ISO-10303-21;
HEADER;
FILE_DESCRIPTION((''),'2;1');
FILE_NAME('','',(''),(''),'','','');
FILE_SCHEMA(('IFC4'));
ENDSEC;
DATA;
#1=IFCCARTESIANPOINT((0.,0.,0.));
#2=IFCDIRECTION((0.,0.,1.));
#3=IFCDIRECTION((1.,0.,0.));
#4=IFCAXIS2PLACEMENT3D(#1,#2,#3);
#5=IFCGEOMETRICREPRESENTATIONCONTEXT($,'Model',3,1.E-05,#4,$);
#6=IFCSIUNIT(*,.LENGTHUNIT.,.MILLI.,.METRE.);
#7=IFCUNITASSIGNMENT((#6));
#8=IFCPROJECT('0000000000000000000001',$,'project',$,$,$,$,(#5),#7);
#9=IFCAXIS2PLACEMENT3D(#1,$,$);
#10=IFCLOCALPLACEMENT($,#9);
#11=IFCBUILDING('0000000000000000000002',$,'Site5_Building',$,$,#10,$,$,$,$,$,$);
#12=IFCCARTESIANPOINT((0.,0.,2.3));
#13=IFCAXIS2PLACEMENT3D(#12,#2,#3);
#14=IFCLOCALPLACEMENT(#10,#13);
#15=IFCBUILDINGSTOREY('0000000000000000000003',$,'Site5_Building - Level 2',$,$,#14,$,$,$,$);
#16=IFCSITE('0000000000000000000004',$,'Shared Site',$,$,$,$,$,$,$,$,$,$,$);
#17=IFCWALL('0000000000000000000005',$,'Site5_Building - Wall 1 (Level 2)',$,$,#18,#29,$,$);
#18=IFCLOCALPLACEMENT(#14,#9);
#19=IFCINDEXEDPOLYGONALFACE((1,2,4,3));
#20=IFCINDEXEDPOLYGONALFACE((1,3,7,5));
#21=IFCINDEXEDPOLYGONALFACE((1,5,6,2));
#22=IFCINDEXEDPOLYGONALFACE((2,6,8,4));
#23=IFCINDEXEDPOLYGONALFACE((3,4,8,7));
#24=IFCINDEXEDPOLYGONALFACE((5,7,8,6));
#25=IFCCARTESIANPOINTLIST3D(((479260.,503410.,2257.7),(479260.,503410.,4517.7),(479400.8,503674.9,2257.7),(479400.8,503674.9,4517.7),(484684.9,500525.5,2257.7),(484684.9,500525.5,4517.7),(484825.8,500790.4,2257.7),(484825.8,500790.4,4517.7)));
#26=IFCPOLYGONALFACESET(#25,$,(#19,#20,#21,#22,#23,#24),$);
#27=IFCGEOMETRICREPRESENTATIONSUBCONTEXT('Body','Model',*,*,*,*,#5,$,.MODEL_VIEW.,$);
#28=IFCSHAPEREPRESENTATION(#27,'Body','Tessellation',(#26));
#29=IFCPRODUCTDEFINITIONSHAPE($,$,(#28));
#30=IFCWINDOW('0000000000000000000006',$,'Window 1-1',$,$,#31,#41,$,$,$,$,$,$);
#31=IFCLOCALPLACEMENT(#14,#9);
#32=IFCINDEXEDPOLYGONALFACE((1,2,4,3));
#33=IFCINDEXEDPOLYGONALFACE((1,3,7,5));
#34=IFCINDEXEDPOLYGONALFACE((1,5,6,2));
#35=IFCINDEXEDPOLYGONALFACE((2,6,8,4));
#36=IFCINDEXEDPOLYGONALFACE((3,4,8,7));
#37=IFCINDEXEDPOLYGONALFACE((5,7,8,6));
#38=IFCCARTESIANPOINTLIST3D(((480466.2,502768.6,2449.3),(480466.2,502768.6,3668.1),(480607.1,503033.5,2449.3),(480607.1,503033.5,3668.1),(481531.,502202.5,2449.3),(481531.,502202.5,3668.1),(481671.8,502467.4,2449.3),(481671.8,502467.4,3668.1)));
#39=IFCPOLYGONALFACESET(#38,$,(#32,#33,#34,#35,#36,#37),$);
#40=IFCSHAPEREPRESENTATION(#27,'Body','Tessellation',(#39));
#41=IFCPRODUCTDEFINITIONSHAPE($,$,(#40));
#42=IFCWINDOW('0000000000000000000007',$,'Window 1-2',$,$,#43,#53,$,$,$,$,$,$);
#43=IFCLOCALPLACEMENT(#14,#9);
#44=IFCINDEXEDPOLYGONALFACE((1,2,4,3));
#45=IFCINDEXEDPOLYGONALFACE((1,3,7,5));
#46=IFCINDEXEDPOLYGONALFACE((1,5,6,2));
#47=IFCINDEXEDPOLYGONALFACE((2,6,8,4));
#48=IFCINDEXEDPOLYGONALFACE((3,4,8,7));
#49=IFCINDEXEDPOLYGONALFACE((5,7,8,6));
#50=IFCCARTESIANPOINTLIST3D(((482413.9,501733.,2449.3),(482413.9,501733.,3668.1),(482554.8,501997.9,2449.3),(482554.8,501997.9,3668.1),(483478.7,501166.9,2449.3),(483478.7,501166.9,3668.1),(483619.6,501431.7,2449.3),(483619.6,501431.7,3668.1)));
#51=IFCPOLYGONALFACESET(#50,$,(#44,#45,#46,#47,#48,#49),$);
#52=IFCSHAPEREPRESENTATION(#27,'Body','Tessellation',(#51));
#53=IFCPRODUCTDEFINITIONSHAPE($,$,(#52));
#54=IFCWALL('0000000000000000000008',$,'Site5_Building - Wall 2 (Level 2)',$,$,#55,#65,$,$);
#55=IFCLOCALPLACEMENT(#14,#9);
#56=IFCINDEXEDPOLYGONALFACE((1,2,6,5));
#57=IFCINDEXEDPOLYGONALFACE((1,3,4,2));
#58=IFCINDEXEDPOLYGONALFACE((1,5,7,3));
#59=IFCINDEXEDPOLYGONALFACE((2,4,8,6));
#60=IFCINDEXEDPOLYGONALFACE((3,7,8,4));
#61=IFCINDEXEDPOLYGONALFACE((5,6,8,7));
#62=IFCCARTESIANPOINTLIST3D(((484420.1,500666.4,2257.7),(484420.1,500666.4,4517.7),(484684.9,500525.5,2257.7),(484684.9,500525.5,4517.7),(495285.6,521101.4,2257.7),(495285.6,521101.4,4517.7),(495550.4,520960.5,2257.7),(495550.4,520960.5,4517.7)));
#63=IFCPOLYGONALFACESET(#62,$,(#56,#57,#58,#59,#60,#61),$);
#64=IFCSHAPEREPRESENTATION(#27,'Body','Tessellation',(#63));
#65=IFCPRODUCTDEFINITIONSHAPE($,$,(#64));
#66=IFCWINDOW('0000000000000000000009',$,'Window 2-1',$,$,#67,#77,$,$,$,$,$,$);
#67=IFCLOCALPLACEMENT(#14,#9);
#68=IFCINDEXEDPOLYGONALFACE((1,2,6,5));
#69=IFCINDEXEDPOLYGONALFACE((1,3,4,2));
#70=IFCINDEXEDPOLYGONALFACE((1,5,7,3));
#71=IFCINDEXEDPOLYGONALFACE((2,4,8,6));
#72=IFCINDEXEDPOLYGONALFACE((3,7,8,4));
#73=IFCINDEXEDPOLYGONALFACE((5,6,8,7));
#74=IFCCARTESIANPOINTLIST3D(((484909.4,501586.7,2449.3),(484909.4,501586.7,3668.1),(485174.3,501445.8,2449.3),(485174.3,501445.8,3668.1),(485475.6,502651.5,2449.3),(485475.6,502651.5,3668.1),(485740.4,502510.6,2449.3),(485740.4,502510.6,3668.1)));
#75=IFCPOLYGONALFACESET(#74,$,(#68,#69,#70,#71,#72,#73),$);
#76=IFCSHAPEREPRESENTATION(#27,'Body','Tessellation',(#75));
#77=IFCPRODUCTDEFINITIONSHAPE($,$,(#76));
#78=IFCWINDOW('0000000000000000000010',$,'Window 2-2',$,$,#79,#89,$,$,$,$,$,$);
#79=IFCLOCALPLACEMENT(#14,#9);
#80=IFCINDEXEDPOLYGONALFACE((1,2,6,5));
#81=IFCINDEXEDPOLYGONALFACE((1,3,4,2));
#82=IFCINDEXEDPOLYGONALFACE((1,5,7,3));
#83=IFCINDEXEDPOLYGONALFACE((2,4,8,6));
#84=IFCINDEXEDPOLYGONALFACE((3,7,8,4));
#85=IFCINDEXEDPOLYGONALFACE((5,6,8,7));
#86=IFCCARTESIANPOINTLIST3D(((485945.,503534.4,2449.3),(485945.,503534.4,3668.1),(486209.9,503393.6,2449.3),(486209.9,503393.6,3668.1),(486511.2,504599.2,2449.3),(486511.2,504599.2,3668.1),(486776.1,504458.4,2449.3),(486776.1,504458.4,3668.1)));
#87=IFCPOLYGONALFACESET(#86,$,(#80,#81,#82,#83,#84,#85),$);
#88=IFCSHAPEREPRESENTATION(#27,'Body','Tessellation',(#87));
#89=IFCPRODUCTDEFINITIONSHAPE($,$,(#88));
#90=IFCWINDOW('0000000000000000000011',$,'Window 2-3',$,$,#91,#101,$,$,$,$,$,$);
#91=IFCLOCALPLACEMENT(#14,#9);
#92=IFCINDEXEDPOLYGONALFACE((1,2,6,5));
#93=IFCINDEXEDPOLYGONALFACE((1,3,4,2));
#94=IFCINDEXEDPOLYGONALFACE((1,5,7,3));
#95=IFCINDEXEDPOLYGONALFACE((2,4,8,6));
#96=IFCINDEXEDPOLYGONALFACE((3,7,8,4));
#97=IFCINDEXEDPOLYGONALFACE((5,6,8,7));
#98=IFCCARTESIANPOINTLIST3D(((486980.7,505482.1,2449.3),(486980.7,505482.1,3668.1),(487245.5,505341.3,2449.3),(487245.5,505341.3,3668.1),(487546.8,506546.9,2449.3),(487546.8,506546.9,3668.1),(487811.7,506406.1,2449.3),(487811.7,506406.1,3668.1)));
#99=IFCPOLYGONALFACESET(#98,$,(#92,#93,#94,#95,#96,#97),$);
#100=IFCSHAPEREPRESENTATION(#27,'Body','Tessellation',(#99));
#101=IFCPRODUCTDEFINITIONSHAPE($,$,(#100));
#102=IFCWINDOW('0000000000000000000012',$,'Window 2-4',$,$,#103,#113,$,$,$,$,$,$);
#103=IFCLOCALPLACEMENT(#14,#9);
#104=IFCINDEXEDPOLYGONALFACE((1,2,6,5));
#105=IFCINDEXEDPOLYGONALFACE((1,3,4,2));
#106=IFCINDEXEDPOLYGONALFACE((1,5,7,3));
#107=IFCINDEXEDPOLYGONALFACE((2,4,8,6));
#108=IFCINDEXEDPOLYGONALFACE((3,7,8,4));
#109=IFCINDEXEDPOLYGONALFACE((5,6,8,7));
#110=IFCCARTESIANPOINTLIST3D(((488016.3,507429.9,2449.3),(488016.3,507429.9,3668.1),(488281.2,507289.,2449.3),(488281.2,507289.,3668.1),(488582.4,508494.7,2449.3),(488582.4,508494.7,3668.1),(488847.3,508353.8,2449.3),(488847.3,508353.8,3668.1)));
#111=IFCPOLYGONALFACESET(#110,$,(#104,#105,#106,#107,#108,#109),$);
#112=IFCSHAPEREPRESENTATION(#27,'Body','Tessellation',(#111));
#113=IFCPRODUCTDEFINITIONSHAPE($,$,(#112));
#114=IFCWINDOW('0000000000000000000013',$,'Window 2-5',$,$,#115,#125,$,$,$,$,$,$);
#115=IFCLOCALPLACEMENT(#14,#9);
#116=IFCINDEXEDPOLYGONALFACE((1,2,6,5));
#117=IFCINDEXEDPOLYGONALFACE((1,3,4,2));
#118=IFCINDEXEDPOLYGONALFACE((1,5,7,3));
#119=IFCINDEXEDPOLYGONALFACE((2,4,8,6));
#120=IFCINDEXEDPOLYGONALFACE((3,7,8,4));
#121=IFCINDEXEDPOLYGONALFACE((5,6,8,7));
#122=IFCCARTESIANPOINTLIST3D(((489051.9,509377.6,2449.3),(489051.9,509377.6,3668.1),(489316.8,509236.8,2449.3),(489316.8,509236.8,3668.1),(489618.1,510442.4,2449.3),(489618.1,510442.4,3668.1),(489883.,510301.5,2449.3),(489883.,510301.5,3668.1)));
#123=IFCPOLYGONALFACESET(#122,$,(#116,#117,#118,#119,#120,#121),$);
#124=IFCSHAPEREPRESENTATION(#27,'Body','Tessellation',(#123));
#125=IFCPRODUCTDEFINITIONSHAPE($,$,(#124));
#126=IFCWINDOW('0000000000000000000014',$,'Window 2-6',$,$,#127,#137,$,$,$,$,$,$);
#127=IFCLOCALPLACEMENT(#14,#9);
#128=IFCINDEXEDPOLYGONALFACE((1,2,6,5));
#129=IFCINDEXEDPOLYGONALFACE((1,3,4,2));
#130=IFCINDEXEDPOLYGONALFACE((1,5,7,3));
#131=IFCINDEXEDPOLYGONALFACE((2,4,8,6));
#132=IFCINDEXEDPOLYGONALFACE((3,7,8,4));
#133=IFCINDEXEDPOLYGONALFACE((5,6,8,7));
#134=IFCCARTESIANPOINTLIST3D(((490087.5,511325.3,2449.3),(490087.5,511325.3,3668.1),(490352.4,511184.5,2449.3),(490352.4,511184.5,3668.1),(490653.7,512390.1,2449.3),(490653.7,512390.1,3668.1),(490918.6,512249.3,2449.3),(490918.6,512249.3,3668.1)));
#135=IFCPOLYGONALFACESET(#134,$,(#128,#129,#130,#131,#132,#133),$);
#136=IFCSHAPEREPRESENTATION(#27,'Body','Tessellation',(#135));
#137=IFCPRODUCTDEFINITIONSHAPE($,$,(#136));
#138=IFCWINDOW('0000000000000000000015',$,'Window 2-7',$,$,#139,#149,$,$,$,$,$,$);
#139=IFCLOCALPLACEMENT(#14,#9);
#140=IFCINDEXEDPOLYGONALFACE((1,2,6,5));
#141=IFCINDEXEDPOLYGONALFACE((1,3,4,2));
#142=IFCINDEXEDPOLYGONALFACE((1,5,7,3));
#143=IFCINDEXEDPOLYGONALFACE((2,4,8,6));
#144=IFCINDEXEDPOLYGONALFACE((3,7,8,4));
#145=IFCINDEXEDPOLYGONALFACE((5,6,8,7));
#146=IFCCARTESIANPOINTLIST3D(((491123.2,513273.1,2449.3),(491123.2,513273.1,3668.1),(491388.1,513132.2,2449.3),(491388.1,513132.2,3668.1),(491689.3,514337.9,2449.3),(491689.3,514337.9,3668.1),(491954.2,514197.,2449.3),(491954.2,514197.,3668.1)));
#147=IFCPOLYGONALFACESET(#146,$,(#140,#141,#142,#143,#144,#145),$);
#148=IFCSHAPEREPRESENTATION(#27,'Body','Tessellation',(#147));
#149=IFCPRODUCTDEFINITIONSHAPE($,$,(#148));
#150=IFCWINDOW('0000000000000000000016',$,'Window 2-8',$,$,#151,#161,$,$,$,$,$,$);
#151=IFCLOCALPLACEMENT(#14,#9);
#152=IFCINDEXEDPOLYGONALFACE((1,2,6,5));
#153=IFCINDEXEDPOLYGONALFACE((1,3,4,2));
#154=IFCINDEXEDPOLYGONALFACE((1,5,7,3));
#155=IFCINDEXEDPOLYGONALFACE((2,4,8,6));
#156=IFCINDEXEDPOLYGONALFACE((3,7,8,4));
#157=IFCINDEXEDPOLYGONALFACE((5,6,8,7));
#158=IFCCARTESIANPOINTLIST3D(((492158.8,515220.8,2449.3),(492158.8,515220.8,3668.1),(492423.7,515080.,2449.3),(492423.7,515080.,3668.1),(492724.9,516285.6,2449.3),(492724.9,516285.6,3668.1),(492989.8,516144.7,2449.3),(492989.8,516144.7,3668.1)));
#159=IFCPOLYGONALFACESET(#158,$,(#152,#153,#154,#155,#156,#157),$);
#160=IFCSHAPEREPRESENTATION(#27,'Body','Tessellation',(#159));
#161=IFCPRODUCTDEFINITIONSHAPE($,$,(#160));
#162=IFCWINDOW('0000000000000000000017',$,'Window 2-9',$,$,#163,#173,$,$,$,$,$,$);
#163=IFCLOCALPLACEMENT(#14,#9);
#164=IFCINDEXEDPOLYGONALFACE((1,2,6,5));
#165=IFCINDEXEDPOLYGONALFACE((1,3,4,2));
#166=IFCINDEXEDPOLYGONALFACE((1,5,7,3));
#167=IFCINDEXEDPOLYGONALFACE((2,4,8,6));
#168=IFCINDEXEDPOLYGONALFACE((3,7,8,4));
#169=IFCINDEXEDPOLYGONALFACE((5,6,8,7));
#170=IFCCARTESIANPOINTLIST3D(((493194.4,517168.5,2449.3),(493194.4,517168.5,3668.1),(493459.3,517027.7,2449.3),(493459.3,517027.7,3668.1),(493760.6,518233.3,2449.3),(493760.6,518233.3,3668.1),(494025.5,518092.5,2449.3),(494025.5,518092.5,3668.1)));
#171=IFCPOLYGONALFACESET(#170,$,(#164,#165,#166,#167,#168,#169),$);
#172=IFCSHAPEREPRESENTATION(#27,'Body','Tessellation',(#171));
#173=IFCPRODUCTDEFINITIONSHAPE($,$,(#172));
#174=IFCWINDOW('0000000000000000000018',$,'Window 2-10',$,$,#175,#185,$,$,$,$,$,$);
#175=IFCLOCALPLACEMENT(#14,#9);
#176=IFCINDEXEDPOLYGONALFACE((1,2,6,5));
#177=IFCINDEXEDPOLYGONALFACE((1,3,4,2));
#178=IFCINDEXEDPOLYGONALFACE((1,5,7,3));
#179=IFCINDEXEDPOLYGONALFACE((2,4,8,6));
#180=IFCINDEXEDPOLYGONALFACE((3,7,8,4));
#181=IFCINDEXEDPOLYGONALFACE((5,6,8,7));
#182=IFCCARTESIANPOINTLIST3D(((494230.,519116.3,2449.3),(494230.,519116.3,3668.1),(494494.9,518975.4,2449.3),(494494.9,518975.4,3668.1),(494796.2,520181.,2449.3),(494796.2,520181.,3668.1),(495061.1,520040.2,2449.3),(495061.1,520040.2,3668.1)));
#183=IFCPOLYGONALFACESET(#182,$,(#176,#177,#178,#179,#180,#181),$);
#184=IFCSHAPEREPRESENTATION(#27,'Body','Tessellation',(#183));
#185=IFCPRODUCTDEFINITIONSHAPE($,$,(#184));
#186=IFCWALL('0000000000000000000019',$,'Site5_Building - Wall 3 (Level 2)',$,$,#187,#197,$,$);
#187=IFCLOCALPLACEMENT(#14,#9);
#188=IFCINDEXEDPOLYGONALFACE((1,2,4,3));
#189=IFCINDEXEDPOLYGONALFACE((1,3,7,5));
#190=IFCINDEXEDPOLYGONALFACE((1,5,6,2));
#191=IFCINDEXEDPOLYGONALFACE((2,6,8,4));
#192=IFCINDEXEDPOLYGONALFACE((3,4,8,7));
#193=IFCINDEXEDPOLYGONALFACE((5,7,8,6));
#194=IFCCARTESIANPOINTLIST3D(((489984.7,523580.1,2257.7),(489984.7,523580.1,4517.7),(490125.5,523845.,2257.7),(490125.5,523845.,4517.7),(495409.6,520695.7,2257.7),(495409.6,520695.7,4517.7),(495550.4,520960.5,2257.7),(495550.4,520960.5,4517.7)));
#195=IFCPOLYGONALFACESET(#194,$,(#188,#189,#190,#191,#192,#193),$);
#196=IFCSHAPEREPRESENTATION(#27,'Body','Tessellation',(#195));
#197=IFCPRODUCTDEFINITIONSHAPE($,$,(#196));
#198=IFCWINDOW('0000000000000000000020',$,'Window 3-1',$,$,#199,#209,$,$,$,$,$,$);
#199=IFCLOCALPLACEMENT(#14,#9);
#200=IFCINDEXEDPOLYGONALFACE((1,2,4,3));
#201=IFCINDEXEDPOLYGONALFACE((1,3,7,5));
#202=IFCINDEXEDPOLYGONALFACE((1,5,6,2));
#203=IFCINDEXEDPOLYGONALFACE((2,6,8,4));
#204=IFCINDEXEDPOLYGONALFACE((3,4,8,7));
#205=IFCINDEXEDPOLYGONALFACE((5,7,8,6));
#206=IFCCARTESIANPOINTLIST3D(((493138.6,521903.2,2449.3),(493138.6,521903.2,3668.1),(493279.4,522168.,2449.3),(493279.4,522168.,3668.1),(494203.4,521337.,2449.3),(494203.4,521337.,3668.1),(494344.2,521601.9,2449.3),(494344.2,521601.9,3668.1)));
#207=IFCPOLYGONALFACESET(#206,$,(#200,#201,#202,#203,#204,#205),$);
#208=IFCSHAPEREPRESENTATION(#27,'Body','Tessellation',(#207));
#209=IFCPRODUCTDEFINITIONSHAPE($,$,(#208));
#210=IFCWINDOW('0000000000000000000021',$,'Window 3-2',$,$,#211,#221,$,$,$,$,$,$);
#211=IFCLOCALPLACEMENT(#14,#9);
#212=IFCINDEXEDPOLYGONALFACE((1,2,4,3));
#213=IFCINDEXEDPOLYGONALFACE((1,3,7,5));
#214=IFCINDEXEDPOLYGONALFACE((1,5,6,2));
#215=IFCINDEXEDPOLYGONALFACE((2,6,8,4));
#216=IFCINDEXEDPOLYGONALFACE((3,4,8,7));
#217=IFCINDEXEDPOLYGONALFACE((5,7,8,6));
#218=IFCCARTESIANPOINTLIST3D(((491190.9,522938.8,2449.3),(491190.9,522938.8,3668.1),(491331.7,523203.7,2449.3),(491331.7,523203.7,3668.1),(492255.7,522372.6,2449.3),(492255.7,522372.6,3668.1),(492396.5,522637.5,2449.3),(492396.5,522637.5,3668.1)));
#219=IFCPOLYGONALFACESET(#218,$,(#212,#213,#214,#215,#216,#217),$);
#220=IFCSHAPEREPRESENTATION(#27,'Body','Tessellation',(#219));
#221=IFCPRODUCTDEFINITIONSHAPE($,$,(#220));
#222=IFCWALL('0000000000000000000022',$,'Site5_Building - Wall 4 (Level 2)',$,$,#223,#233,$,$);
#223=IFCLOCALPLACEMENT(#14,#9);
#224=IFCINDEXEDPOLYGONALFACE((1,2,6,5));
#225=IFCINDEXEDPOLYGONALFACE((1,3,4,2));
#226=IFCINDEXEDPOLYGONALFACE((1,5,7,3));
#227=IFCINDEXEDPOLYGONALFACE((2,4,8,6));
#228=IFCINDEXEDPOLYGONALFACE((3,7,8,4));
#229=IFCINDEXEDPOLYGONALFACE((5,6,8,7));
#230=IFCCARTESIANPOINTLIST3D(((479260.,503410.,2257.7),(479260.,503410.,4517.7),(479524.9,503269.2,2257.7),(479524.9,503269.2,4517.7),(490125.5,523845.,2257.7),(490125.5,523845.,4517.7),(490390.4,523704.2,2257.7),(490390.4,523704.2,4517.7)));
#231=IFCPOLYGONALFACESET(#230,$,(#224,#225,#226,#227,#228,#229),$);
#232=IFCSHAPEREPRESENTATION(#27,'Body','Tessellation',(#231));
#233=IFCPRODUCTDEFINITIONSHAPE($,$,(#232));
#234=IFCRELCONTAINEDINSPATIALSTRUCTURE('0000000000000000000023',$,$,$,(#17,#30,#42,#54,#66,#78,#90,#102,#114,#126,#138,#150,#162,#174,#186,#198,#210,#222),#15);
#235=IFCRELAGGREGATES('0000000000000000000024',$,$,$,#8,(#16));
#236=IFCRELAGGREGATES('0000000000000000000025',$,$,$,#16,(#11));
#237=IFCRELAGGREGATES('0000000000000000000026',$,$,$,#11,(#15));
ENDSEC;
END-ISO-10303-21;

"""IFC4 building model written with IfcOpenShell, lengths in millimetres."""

from ifc_helpers import new_model, si_unit, frame, origin, origin_with_axes, place, context, subcontext, project, spatial, indexed_curve, outline, extrude, element, save


model = new_model("IFC4")

# Units and contexts
model_context = context("Model", 3, precision=1e-05, world=origin_with_axes())
body_context = subcontext(model_context, "Body", "Model", "MODEL_VIEW")
ifc_project = project(units=[si_unit("LENGTHUNIT", "METRE", prefix="MILLI")], contexts=[model_context])

# Site, building, storey
site = spatial("IfcSite", under=ifc_project, Name="Shared Site")
building_placement = place(None, origin())
building = spatial("IfcBuilding", under=site, at=building_placement, Name="Site5_Building")
storey_placement = place(building_placement, frame((0.0, 0.0, 2.3), z_axis=(0.0, 0.0, 1.0), x_axis=(1.0, 0.0, 0.0)))
storey = spatial("IfcBuildingStorey", under=building, at=storey_placement, Name="Site5_Building - Level 2")

# Wall
wall_1_placement = place(storey_placement, frame((479260.0, 503410.0, 2257.7), z_axis=(0.0, 0.0, 1.0), x_axis=(0.882948, -0.469472, 0.0)))
element("IfcWall", 1, at=wall_1_placement, inside=storey, Name="Site5_Building - Wall 1 (Level 2)", context=body_context, shape_type="SweptSolid", body=[
    extrude(outline(indexed_curve([(0.0, 0.0), (0.0, 300.0), (6144.1, 300.0), (6144.1, 0.0), (0.0, 0.0)], self_intersect=False)), origin_with_axes(), (0.0, 0.0, 1.0), 2260.0),
])

# Windows
for number, where, z_axis, x_axis, name in (
    (2, (480466.2, 502768.6, 2449.3), (0.0, 0.0, 1.0), (0.882948, -0.469472, 0.0), "Window 1-1"),
    (3, (482413.9, 501733.0, 2449.3), (0.0, 0.0, 1.0), (0.882948, -0.469472, 0.0), "Window 1-2"),
):
    element("IfcWindow", number, at=place(storey_placement, frame(where, z_axis=z_axis, x_axis=x_axis)), inside=storey, Name=name, context=body_context, shape_type="SweptSolid", body=[
        extrude(outline(indexed_curve([(0.0, 0.0), (0.0, 300.0), (1205.9, 300.0), (1205.9, 0.0), (0.0, 0.0)], self_intersect=False)), origin_with_axes(), (0.0, 0.0, 1.0), 1218.8),
    ])

# Wall
wall_2_placement = place(storey_placement, frame((484684.9, 500525.5, 2257.7), z_axis=(0.0, 0.0, 1.0), x_axis=(0.469472, 0.882948, 0.0)))
element("IfcWall", 4, at=wall_2_placement, inside=storey, Name="Site5_Building - Wall 2 (Level 2)", context=body_context, shape_type="SweptSolid", body=[
    extrude(outline(indexed_curve([(0.0, 0.0), (0.0, 300.0), (23144.1, 300.0), (23144.1, 0.0), (0.0, 0.0)], self_intersect=False)), origin_with_axes(), (0.0, 0.0, 1.0), 2260.0),
])

# Windows
for number, where, z_axis, x_axis, name in (
    (5, (485174.3, 501445.8, 2449.3), (0.0, 0.0, 1.0), (0.469472, 0.882948, 0.0), "Window 2-1"),
    (6, (486209.9, 503393.6, 2449.3), (0.0, 0.0, 1.0), (0.469472, 0.882948, 0.0), "Window 2-2"),
    (7, (487245.5, 505341.3, 2449.3), (0.0, 0.0, 1.0), (0.469472, 0.882948, 0.0), "Window 2-3"),
    (8, (488281.2, 507289.0, 2449.3), (0.0, 0.0, 1.0), (0.469472, 0.882948, 0.0), "Window 2-4"),
    (9, (489316.8, 509236.8, 2449.3), (0.0, 0.0, 1.0), (0.469472, 0.882948, 0.0), "Window 2-5"),
    (10, (490352.4, 511184.5, 2449.3), (0.0, 0.0, 1.0), (0.469472, 0.882948, 0.0), "Window 2-6"),
    (11, (491388.1, 513132.2, 2449.3), (0.0, 0.0, 1.0), (0.469472, 0.882948, 0.0), "Window 2-7"),
    (12, (492423.7, 515080.0, 2449.3), (0.0, 0.0, 1.0), (0.469472, 0.882948, 0.0), "Window 2-8"),
    (13, (493459.3, 517027.7, 2449.3), (0.0, 0.0, 1.0), (0.469472, 0.882948, 0.0), "Window 2-9"),
    (14, (494494.9, 518975.4, 2449.3), (0.0, 0.0, 1.0), (0.469472, 0.882948, 0.0), "Window 2-10"),
):
    element("IfcWindow", number, at=place(storey_placement, frame(where, z_axis=z_axis, x_axis=x_axis)), inside=storey, Name=name, context=body_context, shape_type="SweptSolid", body=[
        extrude(outline(indexed_curve([(0.0, 0.0), (0.0, 300.0), (1205.9, 300.0), (1205.9, 0.0), (0.0, 0.0)], self_intersect=False)), origin_with_axes(), (0.0, 0.0, 1.0), 1218.8),
    ])

# Wall
wall_3_placement = place(storey_placement, frame((495550.4, 520960.5, 2257.7), z_axis=(0.0, 0.0, 1.0), x_axis=(-0.882948, 0.469472, 0.0)))
element("IfcWall", 15, at=wall_3_placement, inside=storey, Name="Site5_Building - Wall 3 (Level 2)", context=body_context, shape_type="SweptSolid", body=[
    extrude(outline(indexed_curve([(0.0, 0.0), (0.0, 300.0), (6144.1, 300.0), (6144.1, 0.0), (0.0, 0.0)], self_intersect=False)), origin_with_axes(), (0.0, 0.0, 1.0), 2260.0),
])

# Windows
for number, where, z_axis, x_axis, name in (
    (16, (494344.2, 521601.9, 2449.3), (0.0, 0.0, 1.0), (-0.882948, 0.469472, 0.0), "Window 3-1"),
    (17, (492396.5, 522637.5, 2449.3), (0.0, 0.0, 1.0), (-0.882948, 0.469472, 0.0), "Window 3-2"),
):
    element("IfcWindow", number, at=place(storey_placement, frame(where, z_axis=z_axis, x_axis=x_axis)), inside=storey, Name=name, context=body_context, shape_type="SweptSolid", body=[
        extrude(outline(indexed_curve([(0.0, 0.0), (0.0, 300.0), (1205.9, 300.0), (1205.9, 0.0), (0.0, 0.0)], self_intersect=False)), origin_with_axes(), (0.0, 0.0, 1.0), 1218.8),
    ])

# Wall
wall_4_placement = place(storey_placement, frame((490125.5, 523845.0, 2257.7), z_axis=(0.0, 0.0, 1.0), x_axis=(-0.469472, -0.882948, 0.0)))
element("IfcWall", 18, at=wall_4_placement, inside=storey, Name="Site5_Building - Wall 4 (Level 2)", context=body_context, shape_type="SweptSolid", body=[
    extrude(outline(indexed_curve([(0.0, 0.0), (0.0, 300.0), (23144.1, 300.0), (23144.1, 0.0), (0.0, 0.0)], self_intersect=False)), origin_with_axes(), (0.0, 0.0, 1.0), 2260.0),
])

save(model, "model.ifc")
